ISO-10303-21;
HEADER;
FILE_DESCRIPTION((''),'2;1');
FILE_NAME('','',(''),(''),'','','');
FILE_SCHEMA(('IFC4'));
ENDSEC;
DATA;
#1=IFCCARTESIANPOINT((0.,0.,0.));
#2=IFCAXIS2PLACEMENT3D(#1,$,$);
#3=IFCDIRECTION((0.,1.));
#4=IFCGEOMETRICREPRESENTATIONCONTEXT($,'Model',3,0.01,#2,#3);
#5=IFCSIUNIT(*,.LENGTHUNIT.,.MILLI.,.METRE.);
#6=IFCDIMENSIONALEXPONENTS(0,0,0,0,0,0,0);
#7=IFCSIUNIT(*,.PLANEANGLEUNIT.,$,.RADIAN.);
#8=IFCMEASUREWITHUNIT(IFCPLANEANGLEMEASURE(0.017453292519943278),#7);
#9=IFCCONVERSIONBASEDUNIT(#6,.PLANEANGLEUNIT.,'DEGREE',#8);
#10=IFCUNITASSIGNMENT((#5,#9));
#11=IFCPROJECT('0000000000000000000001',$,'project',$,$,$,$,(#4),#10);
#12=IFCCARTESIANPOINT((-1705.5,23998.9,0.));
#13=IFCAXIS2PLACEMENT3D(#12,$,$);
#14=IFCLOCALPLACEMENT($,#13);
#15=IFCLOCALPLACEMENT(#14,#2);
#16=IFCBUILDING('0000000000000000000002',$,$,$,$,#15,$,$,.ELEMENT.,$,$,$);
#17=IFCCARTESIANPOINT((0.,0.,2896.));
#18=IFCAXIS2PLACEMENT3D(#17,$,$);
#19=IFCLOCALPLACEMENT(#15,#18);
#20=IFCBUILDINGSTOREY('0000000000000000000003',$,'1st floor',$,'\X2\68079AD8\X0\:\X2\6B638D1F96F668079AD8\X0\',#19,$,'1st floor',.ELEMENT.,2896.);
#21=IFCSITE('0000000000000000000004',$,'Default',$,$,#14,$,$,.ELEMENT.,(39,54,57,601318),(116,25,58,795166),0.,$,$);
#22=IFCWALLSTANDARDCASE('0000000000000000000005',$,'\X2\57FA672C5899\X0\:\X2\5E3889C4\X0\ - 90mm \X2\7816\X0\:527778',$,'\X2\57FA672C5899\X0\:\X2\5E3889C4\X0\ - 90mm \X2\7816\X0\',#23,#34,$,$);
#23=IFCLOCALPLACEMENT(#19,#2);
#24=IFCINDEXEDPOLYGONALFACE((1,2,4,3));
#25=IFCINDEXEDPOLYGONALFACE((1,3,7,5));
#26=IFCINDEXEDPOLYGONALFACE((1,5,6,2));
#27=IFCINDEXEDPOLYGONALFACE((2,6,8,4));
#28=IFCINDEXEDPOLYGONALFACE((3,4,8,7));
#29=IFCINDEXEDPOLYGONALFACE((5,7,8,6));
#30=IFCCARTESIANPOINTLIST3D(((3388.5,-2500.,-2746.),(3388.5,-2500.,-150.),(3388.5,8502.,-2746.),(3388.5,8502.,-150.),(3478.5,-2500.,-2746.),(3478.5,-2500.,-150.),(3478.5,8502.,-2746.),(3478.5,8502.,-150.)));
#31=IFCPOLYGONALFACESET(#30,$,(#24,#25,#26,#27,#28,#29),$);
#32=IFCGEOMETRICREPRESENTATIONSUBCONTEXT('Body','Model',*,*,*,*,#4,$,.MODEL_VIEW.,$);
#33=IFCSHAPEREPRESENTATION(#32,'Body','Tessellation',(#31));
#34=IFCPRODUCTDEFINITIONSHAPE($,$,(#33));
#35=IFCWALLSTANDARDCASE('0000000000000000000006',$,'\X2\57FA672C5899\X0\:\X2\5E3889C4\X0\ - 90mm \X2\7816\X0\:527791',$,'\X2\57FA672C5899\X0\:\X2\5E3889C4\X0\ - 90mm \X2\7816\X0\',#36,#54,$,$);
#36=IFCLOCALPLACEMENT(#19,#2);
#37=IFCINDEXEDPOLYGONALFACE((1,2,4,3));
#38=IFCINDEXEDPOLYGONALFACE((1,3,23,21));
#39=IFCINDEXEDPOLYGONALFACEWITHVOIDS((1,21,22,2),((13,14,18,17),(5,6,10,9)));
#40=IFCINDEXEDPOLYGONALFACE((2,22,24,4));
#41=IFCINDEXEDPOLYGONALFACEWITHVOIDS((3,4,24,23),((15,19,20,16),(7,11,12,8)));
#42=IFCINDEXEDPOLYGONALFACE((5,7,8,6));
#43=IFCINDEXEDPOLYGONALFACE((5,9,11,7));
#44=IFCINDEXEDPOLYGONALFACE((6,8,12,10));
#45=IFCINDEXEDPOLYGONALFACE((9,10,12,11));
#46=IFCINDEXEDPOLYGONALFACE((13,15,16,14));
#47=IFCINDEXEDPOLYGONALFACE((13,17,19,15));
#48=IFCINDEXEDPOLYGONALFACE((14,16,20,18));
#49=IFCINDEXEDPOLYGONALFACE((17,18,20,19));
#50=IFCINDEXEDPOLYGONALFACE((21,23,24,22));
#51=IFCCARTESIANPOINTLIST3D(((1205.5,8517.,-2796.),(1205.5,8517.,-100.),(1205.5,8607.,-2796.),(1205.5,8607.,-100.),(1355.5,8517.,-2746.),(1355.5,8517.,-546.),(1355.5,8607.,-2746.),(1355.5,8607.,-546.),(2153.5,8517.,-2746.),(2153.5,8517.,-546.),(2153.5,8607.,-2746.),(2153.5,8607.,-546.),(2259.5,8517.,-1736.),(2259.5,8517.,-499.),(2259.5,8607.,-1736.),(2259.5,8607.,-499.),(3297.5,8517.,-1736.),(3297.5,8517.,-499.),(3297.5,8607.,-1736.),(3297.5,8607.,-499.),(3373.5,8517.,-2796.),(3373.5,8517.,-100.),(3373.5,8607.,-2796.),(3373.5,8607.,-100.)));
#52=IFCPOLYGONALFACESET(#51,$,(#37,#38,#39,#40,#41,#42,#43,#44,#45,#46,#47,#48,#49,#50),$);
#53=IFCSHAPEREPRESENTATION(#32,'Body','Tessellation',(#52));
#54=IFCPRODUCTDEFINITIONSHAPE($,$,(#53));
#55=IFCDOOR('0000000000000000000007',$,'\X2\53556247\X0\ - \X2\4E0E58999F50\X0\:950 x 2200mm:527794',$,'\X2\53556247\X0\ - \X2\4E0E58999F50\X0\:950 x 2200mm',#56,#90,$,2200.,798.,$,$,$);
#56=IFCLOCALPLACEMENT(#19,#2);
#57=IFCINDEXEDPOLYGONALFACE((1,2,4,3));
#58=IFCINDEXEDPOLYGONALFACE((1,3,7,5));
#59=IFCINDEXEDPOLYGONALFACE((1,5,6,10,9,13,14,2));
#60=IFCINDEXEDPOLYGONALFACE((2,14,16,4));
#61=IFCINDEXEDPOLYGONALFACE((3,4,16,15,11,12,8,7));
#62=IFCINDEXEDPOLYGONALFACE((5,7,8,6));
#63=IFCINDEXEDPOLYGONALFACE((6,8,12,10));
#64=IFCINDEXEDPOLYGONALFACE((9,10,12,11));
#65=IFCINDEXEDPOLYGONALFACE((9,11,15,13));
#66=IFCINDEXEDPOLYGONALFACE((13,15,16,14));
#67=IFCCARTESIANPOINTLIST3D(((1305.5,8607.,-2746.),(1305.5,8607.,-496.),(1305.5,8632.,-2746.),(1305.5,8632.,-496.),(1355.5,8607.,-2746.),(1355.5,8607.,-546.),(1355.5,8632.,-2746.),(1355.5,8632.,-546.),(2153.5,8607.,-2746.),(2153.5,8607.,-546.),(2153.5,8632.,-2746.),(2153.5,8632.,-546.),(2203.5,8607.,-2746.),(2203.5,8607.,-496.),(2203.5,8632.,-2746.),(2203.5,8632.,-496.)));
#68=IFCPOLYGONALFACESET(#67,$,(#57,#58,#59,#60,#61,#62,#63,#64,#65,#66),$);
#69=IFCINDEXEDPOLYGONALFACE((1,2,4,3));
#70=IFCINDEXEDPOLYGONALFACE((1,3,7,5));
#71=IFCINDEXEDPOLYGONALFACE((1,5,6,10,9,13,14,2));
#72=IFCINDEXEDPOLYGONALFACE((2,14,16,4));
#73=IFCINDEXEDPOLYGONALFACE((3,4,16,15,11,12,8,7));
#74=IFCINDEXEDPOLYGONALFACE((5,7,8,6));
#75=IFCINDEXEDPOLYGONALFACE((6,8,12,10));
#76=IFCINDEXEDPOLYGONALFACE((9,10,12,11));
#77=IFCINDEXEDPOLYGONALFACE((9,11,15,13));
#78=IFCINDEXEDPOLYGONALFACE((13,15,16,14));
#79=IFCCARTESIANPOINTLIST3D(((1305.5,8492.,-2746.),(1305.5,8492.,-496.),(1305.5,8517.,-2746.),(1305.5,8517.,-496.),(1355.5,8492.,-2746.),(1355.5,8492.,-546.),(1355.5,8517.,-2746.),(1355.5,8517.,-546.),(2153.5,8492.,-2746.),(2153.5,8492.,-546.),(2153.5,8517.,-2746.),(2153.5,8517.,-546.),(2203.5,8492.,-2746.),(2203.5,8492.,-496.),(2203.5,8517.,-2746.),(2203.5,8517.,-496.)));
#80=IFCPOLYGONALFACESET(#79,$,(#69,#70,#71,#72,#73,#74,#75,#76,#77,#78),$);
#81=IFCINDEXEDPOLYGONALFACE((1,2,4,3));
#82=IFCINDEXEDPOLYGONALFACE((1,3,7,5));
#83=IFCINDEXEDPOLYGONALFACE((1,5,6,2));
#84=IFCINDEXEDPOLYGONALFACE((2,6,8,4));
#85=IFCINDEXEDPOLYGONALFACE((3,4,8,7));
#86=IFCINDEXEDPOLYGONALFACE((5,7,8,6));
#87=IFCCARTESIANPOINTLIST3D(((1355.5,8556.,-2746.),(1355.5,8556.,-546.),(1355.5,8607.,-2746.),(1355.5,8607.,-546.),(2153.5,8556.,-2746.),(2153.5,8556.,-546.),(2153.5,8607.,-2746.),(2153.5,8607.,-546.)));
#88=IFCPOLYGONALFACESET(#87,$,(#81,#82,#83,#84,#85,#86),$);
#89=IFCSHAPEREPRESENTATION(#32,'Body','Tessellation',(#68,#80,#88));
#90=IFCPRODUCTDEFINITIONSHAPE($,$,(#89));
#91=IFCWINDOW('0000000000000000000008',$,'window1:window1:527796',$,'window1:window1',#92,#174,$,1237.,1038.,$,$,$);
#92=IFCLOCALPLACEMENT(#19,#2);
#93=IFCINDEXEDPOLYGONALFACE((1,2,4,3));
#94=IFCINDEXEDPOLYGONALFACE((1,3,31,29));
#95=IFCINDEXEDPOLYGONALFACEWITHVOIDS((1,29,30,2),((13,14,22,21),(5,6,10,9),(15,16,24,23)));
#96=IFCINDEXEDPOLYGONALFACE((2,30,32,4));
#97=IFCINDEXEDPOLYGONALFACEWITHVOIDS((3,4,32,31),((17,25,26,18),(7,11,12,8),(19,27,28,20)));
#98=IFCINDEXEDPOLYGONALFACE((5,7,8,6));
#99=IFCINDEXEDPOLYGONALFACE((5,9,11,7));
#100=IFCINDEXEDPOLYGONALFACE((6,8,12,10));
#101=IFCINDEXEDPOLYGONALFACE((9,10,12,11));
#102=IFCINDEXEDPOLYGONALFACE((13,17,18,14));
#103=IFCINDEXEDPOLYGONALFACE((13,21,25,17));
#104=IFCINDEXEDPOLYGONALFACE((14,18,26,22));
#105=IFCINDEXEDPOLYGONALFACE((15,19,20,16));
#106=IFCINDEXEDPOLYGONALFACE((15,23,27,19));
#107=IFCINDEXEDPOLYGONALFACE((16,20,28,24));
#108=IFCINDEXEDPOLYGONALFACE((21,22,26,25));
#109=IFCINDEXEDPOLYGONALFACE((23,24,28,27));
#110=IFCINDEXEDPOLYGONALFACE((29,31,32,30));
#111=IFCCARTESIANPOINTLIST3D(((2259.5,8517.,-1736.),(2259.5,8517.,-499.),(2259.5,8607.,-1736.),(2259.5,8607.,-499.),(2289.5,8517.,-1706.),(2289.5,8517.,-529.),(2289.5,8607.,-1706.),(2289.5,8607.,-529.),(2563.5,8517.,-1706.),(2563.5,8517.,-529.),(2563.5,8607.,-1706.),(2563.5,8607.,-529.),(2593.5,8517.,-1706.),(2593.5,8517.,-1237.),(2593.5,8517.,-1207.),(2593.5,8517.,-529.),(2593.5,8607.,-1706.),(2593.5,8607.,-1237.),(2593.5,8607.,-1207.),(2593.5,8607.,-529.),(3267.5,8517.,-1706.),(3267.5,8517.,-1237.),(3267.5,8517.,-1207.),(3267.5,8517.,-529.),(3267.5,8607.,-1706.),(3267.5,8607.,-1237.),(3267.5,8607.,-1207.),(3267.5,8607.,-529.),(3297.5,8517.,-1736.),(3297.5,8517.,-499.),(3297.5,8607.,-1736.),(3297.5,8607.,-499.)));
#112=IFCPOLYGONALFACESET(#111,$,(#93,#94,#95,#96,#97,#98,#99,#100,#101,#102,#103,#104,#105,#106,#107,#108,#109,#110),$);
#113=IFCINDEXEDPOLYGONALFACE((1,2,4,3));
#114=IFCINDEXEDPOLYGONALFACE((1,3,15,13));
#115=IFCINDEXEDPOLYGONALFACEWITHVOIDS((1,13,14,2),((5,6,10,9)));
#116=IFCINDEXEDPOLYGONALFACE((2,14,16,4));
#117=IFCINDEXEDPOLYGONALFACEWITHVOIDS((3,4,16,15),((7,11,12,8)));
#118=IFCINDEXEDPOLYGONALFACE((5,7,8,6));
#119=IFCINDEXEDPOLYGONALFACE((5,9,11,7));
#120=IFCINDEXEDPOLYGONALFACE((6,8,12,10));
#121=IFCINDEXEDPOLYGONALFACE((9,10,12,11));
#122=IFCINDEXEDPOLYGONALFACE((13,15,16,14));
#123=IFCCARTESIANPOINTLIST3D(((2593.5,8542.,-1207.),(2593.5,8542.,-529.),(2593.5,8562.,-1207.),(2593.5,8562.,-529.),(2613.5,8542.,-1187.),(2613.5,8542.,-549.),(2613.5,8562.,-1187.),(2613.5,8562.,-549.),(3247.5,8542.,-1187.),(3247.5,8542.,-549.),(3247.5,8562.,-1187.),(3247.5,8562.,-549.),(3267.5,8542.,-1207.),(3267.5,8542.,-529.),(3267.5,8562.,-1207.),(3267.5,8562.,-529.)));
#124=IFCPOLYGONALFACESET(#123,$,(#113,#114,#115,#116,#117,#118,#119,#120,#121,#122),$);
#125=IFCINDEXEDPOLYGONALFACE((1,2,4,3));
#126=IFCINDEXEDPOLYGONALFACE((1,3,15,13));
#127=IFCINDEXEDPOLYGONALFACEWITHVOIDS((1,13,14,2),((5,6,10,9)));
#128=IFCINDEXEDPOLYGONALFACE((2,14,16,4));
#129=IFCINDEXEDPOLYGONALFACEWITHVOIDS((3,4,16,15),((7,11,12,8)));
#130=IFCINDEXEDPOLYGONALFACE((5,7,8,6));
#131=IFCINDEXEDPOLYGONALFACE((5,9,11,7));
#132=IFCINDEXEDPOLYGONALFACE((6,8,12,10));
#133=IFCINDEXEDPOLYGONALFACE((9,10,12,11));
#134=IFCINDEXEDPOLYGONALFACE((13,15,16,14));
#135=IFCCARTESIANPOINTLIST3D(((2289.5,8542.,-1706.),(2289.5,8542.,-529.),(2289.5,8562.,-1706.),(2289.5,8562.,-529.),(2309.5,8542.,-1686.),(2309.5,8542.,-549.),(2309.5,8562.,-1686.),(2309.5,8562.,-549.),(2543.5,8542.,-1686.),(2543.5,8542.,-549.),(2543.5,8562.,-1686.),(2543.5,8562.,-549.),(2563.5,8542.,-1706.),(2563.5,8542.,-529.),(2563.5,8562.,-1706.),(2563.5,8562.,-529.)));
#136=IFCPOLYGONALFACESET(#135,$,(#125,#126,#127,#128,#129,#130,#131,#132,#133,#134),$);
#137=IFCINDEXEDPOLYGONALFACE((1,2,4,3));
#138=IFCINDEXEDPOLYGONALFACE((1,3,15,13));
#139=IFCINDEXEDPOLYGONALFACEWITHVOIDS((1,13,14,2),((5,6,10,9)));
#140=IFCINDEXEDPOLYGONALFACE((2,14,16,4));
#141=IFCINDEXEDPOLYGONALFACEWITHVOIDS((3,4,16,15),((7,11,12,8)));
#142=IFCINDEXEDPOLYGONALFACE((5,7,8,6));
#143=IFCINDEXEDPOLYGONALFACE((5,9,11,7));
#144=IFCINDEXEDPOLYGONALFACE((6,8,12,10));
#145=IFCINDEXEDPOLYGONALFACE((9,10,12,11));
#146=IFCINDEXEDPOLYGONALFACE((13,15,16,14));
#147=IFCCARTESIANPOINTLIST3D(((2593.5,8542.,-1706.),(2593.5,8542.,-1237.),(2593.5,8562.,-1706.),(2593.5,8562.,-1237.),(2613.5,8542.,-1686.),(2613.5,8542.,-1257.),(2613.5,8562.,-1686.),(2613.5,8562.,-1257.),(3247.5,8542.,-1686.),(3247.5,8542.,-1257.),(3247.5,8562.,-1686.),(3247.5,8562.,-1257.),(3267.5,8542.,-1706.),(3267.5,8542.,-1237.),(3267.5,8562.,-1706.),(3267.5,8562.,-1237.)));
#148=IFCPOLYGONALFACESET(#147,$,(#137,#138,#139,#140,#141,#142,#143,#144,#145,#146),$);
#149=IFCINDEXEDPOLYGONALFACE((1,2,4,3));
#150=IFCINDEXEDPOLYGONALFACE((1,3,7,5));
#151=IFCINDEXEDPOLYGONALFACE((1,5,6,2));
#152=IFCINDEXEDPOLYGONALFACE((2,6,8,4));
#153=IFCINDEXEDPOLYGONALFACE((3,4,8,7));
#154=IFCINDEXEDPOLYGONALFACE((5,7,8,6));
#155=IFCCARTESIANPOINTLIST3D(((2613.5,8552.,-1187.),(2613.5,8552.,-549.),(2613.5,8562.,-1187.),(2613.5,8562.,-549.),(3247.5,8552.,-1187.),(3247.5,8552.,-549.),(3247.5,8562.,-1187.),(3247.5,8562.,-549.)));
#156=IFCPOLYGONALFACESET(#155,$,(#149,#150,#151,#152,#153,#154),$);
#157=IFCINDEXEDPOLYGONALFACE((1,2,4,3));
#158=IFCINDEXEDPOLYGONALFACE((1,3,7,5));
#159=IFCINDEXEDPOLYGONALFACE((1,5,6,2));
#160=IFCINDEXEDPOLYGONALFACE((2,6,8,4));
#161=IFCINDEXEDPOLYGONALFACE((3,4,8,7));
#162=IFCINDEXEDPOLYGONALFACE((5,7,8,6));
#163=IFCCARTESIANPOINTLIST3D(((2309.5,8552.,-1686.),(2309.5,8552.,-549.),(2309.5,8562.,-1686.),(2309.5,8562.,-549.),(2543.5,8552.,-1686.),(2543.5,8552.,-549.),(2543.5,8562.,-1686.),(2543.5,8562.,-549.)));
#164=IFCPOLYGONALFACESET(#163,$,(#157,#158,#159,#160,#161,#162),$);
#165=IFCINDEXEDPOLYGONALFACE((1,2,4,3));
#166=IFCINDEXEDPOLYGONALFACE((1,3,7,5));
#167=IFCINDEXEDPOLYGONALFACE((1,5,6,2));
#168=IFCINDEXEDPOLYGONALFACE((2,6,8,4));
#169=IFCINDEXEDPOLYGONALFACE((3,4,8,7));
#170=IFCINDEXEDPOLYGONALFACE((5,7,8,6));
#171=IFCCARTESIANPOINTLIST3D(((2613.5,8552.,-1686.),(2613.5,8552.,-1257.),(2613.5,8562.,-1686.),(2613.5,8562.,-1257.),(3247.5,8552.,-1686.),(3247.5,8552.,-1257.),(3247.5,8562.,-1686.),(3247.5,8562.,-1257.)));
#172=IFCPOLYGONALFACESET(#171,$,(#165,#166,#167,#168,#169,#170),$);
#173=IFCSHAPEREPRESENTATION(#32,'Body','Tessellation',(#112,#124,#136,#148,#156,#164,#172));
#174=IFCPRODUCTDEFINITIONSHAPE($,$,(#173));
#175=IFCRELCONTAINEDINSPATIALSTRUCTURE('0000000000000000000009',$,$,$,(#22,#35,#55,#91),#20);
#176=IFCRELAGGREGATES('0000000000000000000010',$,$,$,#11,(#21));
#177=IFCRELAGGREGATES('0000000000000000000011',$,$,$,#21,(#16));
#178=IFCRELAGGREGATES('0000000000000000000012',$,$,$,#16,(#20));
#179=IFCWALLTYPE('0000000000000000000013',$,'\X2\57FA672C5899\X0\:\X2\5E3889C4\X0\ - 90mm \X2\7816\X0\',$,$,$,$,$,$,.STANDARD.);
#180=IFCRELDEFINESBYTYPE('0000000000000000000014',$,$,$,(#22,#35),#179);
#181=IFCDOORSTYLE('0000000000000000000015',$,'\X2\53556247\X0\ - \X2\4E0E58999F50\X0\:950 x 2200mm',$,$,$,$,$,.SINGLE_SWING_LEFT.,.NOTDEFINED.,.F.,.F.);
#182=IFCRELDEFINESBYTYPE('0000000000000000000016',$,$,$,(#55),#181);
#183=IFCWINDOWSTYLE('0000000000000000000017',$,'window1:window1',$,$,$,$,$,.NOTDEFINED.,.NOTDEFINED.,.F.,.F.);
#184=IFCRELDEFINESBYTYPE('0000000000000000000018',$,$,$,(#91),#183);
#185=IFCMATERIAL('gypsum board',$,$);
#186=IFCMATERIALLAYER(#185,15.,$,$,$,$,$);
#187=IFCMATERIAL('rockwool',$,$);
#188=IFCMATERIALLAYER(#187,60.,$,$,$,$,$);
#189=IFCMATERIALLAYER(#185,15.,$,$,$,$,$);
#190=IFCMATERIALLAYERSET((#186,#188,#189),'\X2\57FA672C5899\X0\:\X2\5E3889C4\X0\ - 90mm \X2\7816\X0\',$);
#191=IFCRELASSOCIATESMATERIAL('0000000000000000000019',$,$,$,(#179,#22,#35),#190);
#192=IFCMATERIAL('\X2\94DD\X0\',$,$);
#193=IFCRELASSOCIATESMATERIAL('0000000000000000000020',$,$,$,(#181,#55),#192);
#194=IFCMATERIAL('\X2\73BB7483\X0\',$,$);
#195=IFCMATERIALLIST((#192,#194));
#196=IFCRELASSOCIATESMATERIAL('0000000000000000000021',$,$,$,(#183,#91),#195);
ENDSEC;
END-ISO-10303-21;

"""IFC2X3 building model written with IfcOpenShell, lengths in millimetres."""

from ifc_helpers import new_model, entity, si_unit, converted_unit, direction, frame, frame_2d, origin, origin_2d_with_axis, place, context, subcontext, project, spatial, polyline, rectangle, outline, extrude, source, transform, mapped, material, material_list, layer, layer_set, layer_usage, type_object, type_shapes, element, fill, save


model = new_model("IFC2X3")

# Units and contexts
model_context = context("Model", 3, precision=0.01, world=origin(), true_north=direction((0.0, 1.0)))
body_context = subcontext(model_context, "Body", "Model", "MODEL_VIEW")
ifc_project = project(units=[si_unit("LENGTHUNIT", "METRE", prefix="MILLI"), converted_unit("PLANEANGLEUNIT", "DEGREE", entity("IfcPlaneAngleMeasure", 0.017453292519943278), si_unit("PLANEANGLEUNIT", "RADIAN"), dimensions=[0, 0, 0, 0, 0, 0, 0])], contexts=[model_context])

# Site, building, storey
site_placement = place(None, frame((-1705.5, 23998.9, 0.0)))
site = spatial("IfcSite", under=ifc_project, at=site_placement, Name="Default", CompositionType="ELEMENT", RefLatitude=(39, 54, 57, 601318), RefLongitude=(116, 25, 58, 795166), RefElevation=0.0)
building_placement = place(site_placement, origin())
building = spatial("IfcBuilding", under=site, at=building_placement, CompositionType="ELEMENT")
storey_placement = place(building_placement, frame((0.0, 0.0, 2896.0)))
storey = spatial("IfcBuildingStorey", under=building, at=storey_placement, Name="1st floor", ObjectType="标高:正负零标高", LongName="1st floor", CompositionType="ELEMENT", Elevation=2896.0)

# Wall
ifc_material_1 = material(Name="gypsum board")
ifc_layer_1 = layer(ifc_material_1, 15.0)
ifc_material_2 = material(Name="rockwool")
ifc_layer_2 = layer(ifc_material_2, 60.0)
ifc_layer_3 = layer(ifc_material_1, 15.0)
ifc_layer_set = layer_set([ifc_layer_1, ifc_layer_2, ifc_layer_3], Name="基本墙:常规 - 90mm 砖")
ifc_layer_usage_1 = layer_usage(ifc_layer_set, "AXIS2", "NEGATIVE", 45.0)
wall_type = type_object("IfcWallType", Name="基本墙:常规 - 90mm 砖", PredefinedType="STANDARD", material=ifc_layer_set)
wall_1_placement = place(storey_placement, frame((3433.5, 8502.0, -2746.0), z_axis=(0.0, 0.0, 1.0), x_axis=(0.0, -1.0, 0.0)))
element("IfcWallStandardCase", 1, at=wall_1_placement, inside=storey, type_object=wall_type, material=ifc_layer_usage_1, Name="基本墙:常规 - 90mm 砖:527778", ObjectType="基本墙:常规 - 90mm 砖", context=body_context, shape_type="SweptSolid", body=[
    extrude(rectangle(XDim=11002.0, YDim=90.0, at=frame_2d((5501.0, 0.0), x_axis=(-1.0, 0.0))), origin(), (0.0, 0.0, 1.0), 2596.0),
])

# Wall, openings, door, window
ifc_layer_usage_2 = layer_usage(ifc_layer_set, "AXIS2", "NEGATIVE", 45.0)
wall_2_placement = place(storey_placement, frame((3373.5, 8562.0, -2796.0), z_axis=(0.0, 0.0, 1.0), x_axis=(-1.0, 0.0, 0.0)))
wall_2 = element("IfcWallStandardCase", 2, at=wall_2_placement, inside=storey, type_object=wall_type, material=ifc_layer_usage_2, Name="基本墙:常规 - 90mm 砖:527791", ObjectType="基本墙:常规 - 90mm 砖", context=body_context, shape_type="SweptSolid", body=[
    extrude(rectangle(XDim=2168.0, YDim=90.0, at=frame_2d((1084.0, 0.0), x_axis=(-1.0, 0.0))), origin(), (0.0, 0.0, 1.0), 2696.0),
])
opening_1_placement = place(wall_2_placement, frame((2018.0, 45.0, 50.0)))
opening_1 = element("IfcOpeningElement", 3, at=opening_1_placement, cuts=wall_2, ObjectType="Opening", context=body_context, shape_type="SweptSolid", body=[
    extrude(rectangle(XDim=798.0, YDim=2200.0, at=frame_2d((1100.0, 399.0), x_axis=(0.0, -1.0))), frame((0.0, 0.0, 0.0), z_axis=(0.0, -1.0, 0.0), x_axis=(0.0, 0.0, 1.0)), (0.0, 0.0, 1.0), 90.0),
])
opening_2_placement = place(wall_2_placement, frame((1114.0, 45.0, 1060.0)))
opening_2 = element("IfcOpeningElement", 4, at=opening_2_placement, cuts=wall_2, ObjectType="Opening", context=body_context, shape_type="SweptSolid", body=[
    extrude(rectangle(XDim=1237.0, YDim=1038.0, at=frame_2d((618.5, 519.0), x_axis=(1.0, 0.0))), frame((0.0, 0.0, 0.0), z_axis=(0.0, -1.0, 0.0), x_axis=(0.0, 0.0, 1.0)), (0.0, 0.0, 1.0), 90.0),
])
ifc_material_3 = material(Name="铝")
door_style = type_object("IfcDoorStyle", Name="单扇 - 与墙齐:950 x 2200mm", ConstructionType="NOTDEFINED", OperationType="SINGLE_SWING_LEFT", ParameterTakesPrecedence=False, Sizeable=False, material=ifc_material_3)
shared_shape_1 = source(origin(), body_context, "Body", "SweptSolid", [
    extrude(outline(polyline([(-449.0, -1137.5), (449.0, -1137.5), (449.0, 1112.5), (399.0, 1112.5), (399.0, -1087.5), (-399.0, -1087.5), (-399.0, 1112.5), (-449.0, 1112.5), (-449.0, -1137.5)])), frame((399.0, 115.0, 1112.5), z_axis=(0.0, -1.0, 0.0), x_axis=(-1.0, 0.0, 0.0)), (0.0, 0.0, 1.0), 25.0),
    extrude(outline(polyline([(-1137.5, -449.0), (1112.5, -449.0), (1112.5, -399.0), (-1087.5, -399.0), (-1087.5, 399.0), (1112.5, 399.0), (1112.5, 449.0), (-1137.5, 449.0), (-1137.5, -449.0)])), frame((399.0, 0.0, 1112.5), z_axis=(0.0, -1.0, 0.0), x_axis=(0.0, 0.0, -1.0)), (0.0, 0.0, 1.0), 25.0),
    extrude(rectangle(XDim=798.0, YDim=51.0, at=origin_2d_with_axis()), frame((399.0, 64.5, 0.0)), (0.0, 0.0, 1.0), 2200.0),
])
type_shapes(door_style, [shared_shape_1])
door_placement = place(opening_1_placement, frame((0.0, 0.0, 0.0), z_axis=(0.0, 0.0, 1.0), x_axis=(-1.0, 0.0, 0.0)))
door = element("IfcDoor", 5, at=door_placement, inside=storey, type_object=door_style, material=ifc_material_3, Name="单扇 - 与墙齐:950 x 2200mm:527794", ObjectType="单扇 - 与墙齐:950 x 2200mm", OverallHeight=2200.0, OverallWidth=798.0, context=body_context, shape_type="MappedRepresentation", body=[
    mapped(shared_shape_1, transform((0.0, 0.0, 0.0), scale=1.0)),
])
fill(opening_1, door)
ifc_material_4 = material(Name="玻璃")
ifc_material_list = material_list([ifc_material_3, ifc_material_4])
window_style = type_object("IfcWindowStyle", Name="window1:window1", ConstructionType="NOTDEFINED", OperationType="NOTDEFINED", ParameterTakesPrecedence=False, Sizeable=False, material=ifc_material_list)
shared_shape_2 = source(origin(), body_context, "Body", "SweptSolid", [
    extrude(outline(polyline([(-618.5, -519.0), (618.5, -519.0), (618.5, 519.0), (-618.5, 519.0), (-618.5, -519.0)]), holes=[polyline([(-588.5, -215.1), (588.5, -215.1), (588.5, -489.0), (-588.5, -489.0), (-588.5, -215.1)]), polyline([(89.5, -185.1), (-588.5, -185.1), (-588.5, 489.0), (89.5, 489.0), (89.5, -185.1)]), polyline([(119.5, 489.0), (588.5, 489.0), (588.5, -185.1), (119.5, -185.1), (119.5, 489.0)])]), frame((519.0, 90.0, 618.5), z_axis=(0.0, -1.0, 0.0), x_axis=(0.0, 0.0, -1.0)), (0.0, 0.0, 1.0), 90.0),
    extrude(outline(polyline([(-337.0, -339.0), (337.0, -339.0), (337.0, 339.0), (-337.0, 339.0), (-337.0, -339.0)]), holes=[polyline([(-317.0, -319.0), (-317.0, 319.0), (317.0, 319.0), (317.0, -319.0), (-317.0, -319.0)])]), frame((671.0, 45.0, 868.0), z_axis=(0.0, -1.0, 0.0), x_axis=(-1.0, 0.0, 0.0)), (0.0, 0.0, 1.0), 20.0),
    extrude(outline(polyline([(-137.0, -588.5), (137.0, -588.5), (137.0, 588.5), (-137.0, 588.5), (-137.0, -588.5)]), holes=[polyline([(-117.0, -568.5), (-117.0, 568.5), (117.0, 568.5), (117.0, -568.5), (-117.0, -568.5)])]), frame((167.0, 45.0, 618.5), z_axis=(0.0, -1.0, 0.0), x_axis=(-1.0, 0.0, 0.0)), (0.0, 0.0, 1.0), 20.0),
    extrude(outline(polyline([(-337.0, -234.5), (337.0, -234.5), (337.0, 234.5), (-337.0, 234.5), (-337.0, -234.5)]), holes=[polyline([(-317.0, -214.5), (-317.0, 214.5), (317.0, 214.5), (317.0, -214.5), (-317.0, -214.5)])]), frame((671.0, 45.0, 264.5), z_axis=(0.0, -1.0, 0.0), x_axis=(-1.0, 0.0, 0.0)), (0.0, 0.0, 1.0), 20.0),
    extrude(rectangle(XDim=634.1, YDim=10.0, at=frame_2d((0.0, 0.0), x_axis=(1.0, 0.0))), frame((671.0, 40.0, 549.0)), (0.0, 0.0, 1.0), 638.0),
    extrude(rectangle(XDim=233.9, YDim=10.0, at=frame_2d((0.0, 0.0), x_axis=(1.0, 0.0))), frame((167.0, 40.0, 50.0)), (0.0, 0.0, 1.0), 1137.0),
    extrude(rectangle(XDim=634.1, YDim=10.0, at=frame_2d((0.0, 0.0), x_axis=(1.0, 0.0))), frame((671.0, 40.0, 50.0)), (0.0, 0.0, 1.0), 429.0),
])
type_shapes(window_style, [shared_shape_2])
window_placement = place(opening_2_placement, frame((0.0, 0.0, 0.0), z_axis=(0.0, 0.0, 1.0), x_axis=(-1.0, 0.0, 0.0)))
window = element("IfcWindow", 6, at=window_placement, inside=storey, type_object=window_style, material=ifc_material_list, Name="window1:window1:527796", ObjectType="window1:window1", OverallHeight=1237.0, OverallWidth=1038.0, context=body_context, shape_type="MappedRepresentation", body=[
    mapped(shared_shape_2, transform((0.0, 0.0, 0.0), scale=1.0)),
])
fill(opening_2, window)

save(model, "model.ifc")
